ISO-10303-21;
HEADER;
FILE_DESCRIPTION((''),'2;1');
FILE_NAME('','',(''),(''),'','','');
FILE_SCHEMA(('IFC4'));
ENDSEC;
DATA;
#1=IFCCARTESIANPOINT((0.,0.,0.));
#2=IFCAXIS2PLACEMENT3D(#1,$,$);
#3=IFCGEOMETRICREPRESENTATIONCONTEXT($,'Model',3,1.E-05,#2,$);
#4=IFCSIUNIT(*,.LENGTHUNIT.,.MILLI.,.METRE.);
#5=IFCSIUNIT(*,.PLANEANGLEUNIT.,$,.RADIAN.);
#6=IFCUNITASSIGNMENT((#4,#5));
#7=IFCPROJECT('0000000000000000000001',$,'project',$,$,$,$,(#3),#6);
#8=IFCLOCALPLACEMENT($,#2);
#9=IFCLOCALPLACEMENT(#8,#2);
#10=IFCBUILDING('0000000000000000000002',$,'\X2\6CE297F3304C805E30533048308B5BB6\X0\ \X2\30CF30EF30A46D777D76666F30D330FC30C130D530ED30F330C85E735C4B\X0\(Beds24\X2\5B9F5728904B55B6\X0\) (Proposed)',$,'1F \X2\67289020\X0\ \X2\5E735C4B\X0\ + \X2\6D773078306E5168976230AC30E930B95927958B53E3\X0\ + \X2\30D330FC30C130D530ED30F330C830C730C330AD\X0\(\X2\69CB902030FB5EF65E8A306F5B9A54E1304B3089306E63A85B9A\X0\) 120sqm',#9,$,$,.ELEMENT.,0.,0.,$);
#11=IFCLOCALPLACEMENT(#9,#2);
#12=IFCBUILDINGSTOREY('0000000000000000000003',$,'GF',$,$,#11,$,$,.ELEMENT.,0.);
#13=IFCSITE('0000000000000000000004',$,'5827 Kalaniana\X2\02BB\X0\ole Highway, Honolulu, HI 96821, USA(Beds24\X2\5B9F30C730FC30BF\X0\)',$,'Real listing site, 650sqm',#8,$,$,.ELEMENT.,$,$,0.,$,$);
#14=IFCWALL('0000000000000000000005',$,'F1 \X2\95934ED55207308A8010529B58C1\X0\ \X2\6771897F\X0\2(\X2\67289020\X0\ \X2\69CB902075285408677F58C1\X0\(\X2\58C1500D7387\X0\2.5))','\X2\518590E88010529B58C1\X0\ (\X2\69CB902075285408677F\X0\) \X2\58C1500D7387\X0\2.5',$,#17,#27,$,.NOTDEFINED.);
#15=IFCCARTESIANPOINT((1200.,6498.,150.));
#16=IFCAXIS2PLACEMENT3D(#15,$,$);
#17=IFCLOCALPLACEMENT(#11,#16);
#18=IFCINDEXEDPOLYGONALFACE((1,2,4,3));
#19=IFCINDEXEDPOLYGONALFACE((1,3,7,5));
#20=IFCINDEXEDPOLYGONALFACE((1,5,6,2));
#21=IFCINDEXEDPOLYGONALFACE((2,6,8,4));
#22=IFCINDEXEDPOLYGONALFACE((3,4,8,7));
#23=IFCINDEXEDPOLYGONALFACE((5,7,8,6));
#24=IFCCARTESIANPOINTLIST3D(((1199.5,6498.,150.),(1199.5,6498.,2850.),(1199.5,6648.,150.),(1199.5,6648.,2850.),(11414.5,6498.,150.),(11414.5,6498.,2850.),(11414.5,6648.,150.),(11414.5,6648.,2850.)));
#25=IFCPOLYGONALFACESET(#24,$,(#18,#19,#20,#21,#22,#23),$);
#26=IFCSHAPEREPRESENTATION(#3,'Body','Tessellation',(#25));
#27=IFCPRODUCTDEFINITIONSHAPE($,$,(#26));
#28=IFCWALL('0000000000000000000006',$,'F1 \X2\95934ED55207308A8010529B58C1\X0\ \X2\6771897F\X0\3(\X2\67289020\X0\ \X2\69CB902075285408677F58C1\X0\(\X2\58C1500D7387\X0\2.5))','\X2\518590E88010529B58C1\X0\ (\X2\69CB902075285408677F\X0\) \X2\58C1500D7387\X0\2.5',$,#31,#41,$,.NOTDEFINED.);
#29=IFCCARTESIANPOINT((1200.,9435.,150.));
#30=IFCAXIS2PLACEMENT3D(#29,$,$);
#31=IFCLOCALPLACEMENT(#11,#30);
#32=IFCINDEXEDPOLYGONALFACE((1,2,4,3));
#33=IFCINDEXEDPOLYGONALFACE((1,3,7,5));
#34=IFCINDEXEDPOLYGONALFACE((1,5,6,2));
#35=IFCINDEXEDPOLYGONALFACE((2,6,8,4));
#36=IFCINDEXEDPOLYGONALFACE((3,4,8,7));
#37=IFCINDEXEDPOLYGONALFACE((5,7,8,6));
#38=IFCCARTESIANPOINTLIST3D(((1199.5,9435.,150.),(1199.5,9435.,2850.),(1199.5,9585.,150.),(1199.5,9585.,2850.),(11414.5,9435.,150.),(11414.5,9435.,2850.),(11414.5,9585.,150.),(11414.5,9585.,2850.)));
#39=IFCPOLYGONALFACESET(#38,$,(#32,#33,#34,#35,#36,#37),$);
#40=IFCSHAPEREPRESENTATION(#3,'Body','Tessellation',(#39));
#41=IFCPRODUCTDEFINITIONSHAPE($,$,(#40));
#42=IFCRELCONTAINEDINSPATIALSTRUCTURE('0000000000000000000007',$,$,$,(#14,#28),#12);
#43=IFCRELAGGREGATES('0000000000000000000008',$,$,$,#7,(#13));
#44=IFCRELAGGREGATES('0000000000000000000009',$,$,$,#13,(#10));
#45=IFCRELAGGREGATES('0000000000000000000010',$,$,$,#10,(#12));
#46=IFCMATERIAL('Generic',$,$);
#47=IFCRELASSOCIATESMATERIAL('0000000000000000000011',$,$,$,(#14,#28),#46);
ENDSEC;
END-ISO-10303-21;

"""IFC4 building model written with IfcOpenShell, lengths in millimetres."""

from ifc_helpers import new_model, si_unit, frame, frame_2d, origin, place, context, project, spatial, rectangle, extrude, material, element, save


model = new_model("IFC4")

# Units and contexts
model_context = context("Model", 3, precision=1e-05, world=origin())
ifc_project = project(units=[si_unit("LENGTHUNIT", "METRE", prefix="MILLI"), si_unit("PLANEANGLEUNIT", "RADIAN")], contexts=[model_context])

# Site, building, storey
site_placement = place(None, origin())
site = spatial("IfcSite", under=ifc_project, at=site_placement, Name="5827 Kalanianaʻole Highway, Honolulu, HI 96821, USA(Beds24実データ)", ObjectType="Real listing site, 650sqm", CompositionType="ELEMENT", RefElevation=0.0)
building_placement = place(site_placement, origin())
building = spatial("IfcBuilding", under=site, at=building_placement, Name="波音が聞こえる家 ハワイ海絶景ビーチフロント平屋(Beds24実在運営) (Proposed)", ObjectType="1F 木造 平屋 + 海への全面ガラス大開口 + ビーチフロントデッキ(構造・延床は定員からの推定) 120sqm", CompositionType="ELEMENT", ElevationOfRefHeight=0.0, ElevationOfTerrain=0.0)
storey_placement = place(building_placement, origin())
storey = spatial("IfcBuildingStorey", under=building, at=storey_placement, Name="GF", CompositionType="ELEMENT", Elevation=0.0)

# Shared definitions
ifc_material_1 = material(Name="Generic")

# Walls
wall_1_placement = place(storey_placement, frame((1200.0, 6498.0, 150.0)))
element("IfcWall", 1, at=wall_1_placement, inside=storey, material=ifc_material_1, Name="F1 間仕切り耐力壁 東西2(木造 構造用合板壁(壁倍率2.5))", Description="内部耐力壁 (構造用合板) 壁倍率2.5", PredefinedType="NOTDEFINED", context=model_context, shape_type="SweptSolid", body=[
    extrude(rectangle(XDim=10215.0, YDim=150.0, at=frame_2d((5107.0, 75.0))), frame((1200.0, 6498.0, 150.0)), (0.0, 0.0, 1.0), 2700.0),
])
wall_2_placement = place(storey_placement, frame((1200.0, 9435.0, 150.0)))
element("IfcWall", 2, at=wall_2_placement, inside=storey, material=ifc_material_1, Name="F1 間仕切り耐力壁 東西3(木造 構造用合板壁(壁倍率2.5))", Description="内部耐力壁 (構造用合板) 壁倍率2.5", PredefinedType="NOTDEFINED", context=model_context, shape_type="SweptSolid", body=[
    extrude(rectangle(XDim=10215.0, YDim=150.0, at=frame_2d((5107.0, 75.0))), frame((1200.0, 9435.0, 150.0)), (0.0, 0.0, 1.0), 2700.0),
])

save(model, "model.ifc")
